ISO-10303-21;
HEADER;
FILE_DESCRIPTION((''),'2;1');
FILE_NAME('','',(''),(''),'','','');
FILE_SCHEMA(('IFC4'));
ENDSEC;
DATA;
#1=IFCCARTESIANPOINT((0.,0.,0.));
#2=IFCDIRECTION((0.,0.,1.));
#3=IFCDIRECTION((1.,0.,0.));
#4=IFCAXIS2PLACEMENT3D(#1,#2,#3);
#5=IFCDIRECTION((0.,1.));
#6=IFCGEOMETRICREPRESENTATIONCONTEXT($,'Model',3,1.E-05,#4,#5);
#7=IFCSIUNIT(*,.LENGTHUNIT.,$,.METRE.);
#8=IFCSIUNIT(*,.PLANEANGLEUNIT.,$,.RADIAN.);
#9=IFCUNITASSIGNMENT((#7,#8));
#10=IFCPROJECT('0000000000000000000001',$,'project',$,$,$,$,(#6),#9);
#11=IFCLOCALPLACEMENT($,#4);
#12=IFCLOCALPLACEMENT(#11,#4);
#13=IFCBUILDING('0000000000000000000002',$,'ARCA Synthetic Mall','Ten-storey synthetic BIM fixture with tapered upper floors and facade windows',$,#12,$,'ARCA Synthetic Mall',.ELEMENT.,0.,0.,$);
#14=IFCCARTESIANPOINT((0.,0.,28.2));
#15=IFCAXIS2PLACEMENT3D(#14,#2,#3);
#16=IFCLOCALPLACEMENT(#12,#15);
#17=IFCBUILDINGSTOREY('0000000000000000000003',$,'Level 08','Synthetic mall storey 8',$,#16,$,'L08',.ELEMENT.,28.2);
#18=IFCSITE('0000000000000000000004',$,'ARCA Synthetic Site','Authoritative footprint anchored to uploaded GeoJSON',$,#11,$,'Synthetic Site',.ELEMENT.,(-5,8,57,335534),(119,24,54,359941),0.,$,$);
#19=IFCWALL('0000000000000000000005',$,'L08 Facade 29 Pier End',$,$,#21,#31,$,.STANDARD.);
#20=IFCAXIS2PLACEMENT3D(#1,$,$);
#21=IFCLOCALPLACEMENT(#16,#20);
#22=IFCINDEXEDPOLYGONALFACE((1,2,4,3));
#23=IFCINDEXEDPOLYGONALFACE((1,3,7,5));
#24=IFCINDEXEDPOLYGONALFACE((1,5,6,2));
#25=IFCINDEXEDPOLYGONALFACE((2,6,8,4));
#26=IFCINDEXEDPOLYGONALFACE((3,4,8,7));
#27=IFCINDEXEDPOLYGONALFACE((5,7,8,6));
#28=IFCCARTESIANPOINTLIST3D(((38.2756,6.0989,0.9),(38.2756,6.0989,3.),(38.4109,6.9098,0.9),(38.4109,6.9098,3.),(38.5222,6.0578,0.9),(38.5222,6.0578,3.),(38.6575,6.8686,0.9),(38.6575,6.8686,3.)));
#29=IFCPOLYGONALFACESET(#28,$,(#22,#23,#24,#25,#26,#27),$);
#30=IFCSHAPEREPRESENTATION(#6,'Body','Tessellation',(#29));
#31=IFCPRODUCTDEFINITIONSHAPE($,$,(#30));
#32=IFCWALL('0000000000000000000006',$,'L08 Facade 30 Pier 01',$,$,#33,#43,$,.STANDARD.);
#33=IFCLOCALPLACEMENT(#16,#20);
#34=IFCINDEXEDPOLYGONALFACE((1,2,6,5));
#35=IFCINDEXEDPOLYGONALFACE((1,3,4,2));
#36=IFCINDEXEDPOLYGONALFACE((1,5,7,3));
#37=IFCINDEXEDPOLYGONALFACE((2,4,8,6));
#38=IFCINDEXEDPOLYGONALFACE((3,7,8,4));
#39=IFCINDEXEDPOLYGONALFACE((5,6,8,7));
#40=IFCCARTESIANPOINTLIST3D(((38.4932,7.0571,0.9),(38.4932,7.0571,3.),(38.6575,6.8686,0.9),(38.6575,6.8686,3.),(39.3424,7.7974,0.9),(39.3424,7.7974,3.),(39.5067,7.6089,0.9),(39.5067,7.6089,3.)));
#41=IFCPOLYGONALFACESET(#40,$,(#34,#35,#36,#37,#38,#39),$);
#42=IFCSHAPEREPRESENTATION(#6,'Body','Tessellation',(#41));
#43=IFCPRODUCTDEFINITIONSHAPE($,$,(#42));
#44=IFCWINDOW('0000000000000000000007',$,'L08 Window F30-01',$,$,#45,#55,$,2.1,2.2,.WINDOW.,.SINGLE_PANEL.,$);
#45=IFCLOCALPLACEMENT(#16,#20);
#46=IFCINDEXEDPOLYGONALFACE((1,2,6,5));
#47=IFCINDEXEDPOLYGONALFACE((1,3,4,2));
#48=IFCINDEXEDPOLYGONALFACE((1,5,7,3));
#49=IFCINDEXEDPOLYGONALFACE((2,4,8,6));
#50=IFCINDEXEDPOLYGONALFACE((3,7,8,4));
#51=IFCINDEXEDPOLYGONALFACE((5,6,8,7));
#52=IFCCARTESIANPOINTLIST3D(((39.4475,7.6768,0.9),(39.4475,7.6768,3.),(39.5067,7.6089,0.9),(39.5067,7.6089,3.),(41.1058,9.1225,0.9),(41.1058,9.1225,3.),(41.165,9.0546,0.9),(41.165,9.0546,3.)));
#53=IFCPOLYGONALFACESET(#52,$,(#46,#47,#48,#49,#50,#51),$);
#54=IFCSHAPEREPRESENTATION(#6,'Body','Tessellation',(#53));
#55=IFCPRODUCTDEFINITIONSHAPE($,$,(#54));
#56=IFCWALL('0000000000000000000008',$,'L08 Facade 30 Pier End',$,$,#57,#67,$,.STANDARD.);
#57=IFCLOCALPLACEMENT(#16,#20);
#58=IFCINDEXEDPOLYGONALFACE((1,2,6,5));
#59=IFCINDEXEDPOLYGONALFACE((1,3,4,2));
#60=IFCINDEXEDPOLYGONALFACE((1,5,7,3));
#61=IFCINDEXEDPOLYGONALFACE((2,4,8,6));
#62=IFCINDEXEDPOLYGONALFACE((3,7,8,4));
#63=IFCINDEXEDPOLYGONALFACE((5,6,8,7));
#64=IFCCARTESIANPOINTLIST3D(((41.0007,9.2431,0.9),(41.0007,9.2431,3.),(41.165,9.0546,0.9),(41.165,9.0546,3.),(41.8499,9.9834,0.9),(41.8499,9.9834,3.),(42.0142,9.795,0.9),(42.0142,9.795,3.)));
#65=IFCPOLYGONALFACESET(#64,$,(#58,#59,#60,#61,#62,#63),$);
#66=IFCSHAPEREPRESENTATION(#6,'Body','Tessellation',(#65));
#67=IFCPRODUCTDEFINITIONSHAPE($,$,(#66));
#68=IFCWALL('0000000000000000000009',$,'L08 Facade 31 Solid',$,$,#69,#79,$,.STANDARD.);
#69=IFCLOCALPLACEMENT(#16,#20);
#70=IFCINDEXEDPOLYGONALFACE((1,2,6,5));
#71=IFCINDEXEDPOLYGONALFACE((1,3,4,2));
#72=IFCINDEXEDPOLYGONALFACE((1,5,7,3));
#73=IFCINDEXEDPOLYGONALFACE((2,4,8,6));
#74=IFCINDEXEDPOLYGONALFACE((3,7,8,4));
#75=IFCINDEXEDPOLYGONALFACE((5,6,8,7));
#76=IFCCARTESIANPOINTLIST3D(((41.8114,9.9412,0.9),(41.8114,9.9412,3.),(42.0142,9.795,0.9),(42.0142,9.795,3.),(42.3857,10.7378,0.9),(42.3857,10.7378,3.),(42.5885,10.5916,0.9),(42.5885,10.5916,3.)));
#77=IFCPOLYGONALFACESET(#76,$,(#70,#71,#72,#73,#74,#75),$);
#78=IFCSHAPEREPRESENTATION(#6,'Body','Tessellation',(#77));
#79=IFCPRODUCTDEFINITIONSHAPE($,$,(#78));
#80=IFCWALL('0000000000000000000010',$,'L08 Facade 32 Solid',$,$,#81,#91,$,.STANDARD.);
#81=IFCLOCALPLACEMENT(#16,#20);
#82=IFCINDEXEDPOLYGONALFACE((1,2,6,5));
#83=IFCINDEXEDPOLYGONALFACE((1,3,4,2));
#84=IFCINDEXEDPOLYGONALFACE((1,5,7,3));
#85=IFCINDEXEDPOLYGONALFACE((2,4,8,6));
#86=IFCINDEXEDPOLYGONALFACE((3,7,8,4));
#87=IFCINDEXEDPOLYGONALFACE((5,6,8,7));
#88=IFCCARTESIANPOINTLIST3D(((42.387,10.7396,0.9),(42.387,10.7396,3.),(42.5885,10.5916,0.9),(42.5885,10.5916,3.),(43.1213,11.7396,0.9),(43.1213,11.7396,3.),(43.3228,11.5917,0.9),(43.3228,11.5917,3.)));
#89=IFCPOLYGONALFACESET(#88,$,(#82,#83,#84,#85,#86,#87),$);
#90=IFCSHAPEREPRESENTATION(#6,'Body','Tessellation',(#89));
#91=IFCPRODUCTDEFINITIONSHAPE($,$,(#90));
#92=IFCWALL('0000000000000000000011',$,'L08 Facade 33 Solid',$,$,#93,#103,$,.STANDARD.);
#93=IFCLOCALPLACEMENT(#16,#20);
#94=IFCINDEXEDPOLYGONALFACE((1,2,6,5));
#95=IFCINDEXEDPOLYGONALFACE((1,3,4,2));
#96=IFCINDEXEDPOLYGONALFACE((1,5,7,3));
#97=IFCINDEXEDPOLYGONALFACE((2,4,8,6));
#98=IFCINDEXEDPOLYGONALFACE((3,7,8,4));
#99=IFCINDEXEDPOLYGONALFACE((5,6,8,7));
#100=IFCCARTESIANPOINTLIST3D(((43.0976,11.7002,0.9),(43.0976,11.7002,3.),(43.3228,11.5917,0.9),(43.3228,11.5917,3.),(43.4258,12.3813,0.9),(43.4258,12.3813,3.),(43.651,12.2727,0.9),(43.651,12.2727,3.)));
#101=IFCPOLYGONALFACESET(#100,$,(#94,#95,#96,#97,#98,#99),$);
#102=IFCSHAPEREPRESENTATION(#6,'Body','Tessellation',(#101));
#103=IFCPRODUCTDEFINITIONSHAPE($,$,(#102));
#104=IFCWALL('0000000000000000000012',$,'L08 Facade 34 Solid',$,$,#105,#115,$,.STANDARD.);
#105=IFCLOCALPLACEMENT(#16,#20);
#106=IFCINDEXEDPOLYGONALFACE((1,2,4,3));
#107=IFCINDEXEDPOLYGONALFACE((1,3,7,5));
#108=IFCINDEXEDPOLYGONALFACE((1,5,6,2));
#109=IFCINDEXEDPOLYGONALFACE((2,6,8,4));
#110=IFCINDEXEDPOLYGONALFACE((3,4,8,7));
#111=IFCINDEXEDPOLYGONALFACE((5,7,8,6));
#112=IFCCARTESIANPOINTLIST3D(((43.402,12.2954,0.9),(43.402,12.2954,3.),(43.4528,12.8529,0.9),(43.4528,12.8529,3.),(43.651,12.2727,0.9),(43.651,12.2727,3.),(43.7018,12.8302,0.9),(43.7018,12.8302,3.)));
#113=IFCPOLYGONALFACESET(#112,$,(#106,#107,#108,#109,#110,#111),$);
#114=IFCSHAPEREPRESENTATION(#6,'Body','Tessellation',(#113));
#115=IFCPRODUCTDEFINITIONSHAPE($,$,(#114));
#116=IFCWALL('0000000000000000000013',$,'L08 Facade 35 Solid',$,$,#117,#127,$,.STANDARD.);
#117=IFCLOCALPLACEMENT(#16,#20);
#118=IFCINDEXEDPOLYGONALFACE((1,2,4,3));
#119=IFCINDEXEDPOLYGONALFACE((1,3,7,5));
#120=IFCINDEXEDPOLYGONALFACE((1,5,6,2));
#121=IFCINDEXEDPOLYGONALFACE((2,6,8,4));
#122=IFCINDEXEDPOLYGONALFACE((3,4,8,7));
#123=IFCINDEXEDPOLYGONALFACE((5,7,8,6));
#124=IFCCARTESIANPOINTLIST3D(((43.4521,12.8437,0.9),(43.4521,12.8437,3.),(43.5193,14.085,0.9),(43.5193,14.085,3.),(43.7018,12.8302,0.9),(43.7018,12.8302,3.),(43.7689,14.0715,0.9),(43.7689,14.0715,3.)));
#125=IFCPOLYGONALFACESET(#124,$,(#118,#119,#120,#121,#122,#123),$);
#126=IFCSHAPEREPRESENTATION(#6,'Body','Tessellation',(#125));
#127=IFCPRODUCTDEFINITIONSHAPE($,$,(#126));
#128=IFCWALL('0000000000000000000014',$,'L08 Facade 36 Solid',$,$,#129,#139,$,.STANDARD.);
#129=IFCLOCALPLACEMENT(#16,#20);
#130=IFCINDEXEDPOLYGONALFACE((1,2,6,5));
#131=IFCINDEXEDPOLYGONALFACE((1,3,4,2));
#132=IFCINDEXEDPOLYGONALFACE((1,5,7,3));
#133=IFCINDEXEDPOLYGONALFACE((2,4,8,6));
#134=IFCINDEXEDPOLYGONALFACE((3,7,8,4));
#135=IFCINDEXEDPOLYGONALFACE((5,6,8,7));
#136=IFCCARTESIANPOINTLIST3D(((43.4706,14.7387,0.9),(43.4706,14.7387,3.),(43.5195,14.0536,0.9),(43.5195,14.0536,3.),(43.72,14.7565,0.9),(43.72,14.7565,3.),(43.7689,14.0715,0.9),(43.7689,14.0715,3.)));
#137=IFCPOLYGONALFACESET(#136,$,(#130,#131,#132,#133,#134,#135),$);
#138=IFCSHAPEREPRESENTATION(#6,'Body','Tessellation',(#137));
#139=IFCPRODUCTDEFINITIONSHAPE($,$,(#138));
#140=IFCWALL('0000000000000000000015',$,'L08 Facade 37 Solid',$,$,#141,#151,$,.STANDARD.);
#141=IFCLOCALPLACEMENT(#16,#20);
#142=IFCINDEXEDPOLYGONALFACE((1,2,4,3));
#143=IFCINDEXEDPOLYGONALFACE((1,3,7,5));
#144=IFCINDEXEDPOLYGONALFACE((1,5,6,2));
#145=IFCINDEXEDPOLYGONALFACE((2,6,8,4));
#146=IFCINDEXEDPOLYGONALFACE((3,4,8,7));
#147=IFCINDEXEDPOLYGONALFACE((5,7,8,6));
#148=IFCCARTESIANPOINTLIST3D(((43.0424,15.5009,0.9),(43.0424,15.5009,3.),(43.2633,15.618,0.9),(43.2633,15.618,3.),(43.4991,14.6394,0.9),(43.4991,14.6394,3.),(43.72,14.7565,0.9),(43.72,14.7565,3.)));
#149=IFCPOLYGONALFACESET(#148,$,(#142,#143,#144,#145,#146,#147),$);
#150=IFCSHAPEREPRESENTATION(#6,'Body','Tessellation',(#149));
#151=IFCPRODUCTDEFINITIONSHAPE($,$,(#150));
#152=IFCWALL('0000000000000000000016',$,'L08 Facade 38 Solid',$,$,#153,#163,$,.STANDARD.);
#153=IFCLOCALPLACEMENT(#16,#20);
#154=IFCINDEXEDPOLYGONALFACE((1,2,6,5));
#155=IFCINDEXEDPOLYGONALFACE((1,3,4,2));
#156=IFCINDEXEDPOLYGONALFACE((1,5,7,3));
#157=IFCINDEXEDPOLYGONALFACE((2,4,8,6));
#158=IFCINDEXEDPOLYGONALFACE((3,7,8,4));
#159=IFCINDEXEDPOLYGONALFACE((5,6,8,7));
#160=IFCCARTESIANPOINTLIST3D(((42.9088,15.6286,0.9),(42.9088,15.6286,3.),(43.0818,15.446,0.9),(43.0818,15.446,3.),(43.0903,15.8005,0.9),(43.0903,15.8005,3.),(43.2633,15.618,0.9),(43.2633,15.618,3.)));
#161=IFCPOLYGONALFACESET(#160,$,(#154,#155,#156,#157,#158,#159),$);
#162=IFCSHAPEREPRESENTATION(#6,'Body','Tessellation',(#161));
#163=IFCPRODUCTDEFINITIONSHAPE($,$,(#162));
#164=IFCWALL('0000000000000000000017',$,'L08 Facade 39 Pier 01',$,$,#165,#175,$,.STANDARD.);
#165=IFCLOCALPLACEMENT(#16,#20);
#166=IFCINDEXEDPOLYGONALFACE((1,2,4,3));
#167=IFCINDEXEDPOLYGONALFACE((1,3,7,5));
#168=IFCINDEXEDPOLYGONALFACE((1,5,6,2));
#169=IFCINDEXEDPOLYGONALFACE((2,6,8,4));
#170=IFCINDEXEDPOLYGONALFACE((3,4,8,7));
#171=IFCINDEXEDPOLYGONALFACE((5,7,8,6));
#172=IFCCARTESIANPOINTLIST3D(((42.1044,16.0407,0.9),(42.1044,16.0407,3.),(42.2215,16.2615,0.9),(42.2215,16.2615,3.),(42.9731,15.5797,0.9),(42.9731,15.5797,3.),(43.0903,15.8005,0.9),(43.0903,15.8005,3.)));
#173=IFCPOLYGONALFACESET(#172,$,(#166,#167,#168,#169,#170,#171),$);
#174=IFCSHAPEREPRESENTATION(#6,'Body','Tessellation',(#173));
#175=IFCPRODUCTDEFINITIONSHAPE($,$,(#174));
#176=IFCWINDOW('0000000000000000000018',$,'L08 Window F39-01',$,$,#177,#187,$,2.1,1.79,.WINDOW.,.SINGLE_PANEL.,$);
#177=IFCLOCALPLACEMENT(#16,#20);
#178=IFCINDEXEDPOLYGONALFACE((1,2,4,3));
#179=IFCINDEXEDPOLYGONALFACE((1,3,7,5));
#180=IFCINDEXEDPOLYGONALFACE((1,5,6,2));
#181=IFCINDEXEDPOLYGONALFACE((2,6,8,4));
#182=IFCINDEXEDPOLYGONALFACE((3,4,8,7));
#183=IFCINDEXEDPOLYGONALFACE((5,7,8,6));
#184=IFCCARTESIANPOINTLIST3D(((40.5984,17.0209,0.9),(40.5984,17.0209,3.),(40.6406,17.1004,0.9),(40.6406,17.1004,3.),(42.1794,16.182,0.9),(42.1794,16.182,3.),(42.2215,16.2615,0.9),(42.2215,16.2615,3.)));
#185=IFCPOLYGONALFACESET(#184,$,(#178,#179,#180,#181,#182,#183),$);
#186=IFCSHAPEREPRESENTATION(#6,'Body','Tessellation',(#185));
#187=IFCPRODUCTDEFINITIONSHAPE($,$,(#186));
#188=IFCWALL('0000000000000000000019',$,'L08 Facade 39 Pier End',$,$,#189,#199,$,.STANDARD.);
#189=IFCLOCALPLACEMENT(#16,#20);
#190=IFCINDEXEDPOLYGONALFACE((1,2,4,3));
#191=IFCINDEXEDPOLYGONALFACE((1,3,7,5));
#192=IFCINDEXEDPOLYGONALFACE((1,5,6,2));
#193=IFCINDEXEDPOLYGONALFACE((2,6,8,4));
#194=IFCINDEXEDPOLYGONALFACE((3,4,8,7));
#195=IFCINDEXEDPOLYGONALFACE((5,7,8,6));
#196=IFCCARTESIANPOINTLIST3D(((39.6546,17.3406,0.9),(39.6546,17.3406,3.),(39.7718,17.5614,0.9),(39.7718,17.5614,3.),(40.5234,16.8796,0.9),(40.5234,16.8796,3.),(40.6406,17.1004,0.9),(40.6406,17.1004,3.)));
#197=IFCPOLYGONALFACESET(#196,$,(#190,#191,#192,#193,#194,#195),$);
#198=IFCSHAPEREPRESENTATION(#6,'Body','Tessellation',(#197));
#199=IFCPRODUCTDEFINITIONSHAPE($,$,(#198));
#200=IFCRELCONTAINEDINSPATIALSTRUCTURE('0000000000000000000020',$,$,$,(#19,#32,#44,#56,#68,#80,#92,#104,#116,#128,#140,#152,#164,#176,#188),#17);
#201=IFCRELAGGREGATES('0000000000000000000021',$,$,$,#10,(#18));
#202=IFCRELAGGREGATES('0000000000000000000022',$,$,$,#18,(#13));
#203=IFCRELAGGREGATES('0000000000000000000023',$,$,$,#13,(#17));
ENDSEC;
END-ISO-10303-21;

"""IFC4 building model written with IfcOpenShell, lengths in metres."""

from ifc_helpers import new_model, si_unit, direction, frame, origin_with_axes, place, context, project, spatial, polyline, outline, extrude, element, save


model = new_model("IFC4")

# Units and contexts
model_context = context("Model", 3, precision=1e-05, world=origin_with_axes(), true_north=direction((0.0, 1.0)))
ifc_project = project(units=[si_unit("LENGTHUNIT", "METRE"), si_unit("PLANEANGLEUNIT", "RADIAN")], contexts=[model_context])

# Site, building, storey
site_placement = place(None, origin_with_axes())
site = spatial("IfcSite", under=ifc_project, at=site_placement, Name="ARCA Synthetic Site", Description="Authoritative footprint anchored to uploaded GeoJSON", LongName="Synthetic Site", CompositionType="ELEMENT", RefLatitude=(-5, 8, 57, 335534), RefLongitude=(119, 24, 54, 359941), RefElevation=0.0)
building_placement = place(site_placement, origin_with_axes())
building = spatial("IfcBuilding", under=site, at=building_placement, Name="ARCA Synthetic Mall", Description="Ten-storey synthetic BIM fixture with tapered upper floors and facade windows", LongName="ARCA Synthetic Mall", CompositionType="ELEMENT", ElevationOfRefHeight=0.0, ElevationOfTerrain=0.0)
storey_placement = place(building_placement, frame((0.0, 0.0, 28.2), z_axis=(0.0, 0.0, 1.0), x_axis=(1.0, 0.0, 0.0)))
storey = spatial("IfcBuildingStorey", under=building, at=storey_placement, Name="Level 08", Description="Synthetic mall storey 8", LongName="L08", CompositionType="ELEMENT", Elevation=28.2)

# Walls
wall_1_placement = place(storey_placement, frame((0.0, 0.0, 0.9), z_axis=(0.0, 0.0, 1.0), x_axis=(1.0, 0.0, 0.0)))
element("IfcWall", 1, at=wall_1_placement, inside=storey, Name="L08 Facade 29 Pier End", PredefinedType="STANDARD", context=model_context, shape_type="SweptSolid", body=[
    extrude(outline(polyline([(38.5222, 6.0578), (38.6575, 6.8686), (38.4109, 6.9098), (38.2756, 6.0989), (38.5222, 6.0578)])), origin_with_axes(), (0.0, 0.0, 1.0), 2.1),
])
wall_2_placement = place(storey_placement, frame((0.0, 0.0, 0.9), z_axis=(0.0, 0.0, 1.0), x_axis=(1.0, 0.0, 0.0)))
element("IfcWall", 2, at=wall_2_placement, inside=storey, Name="L08 Facade 30 Pier 01", PredefinedType="STANDARD", context=model_context, shape_type="SweptSolid", body=[
    extrude(outline(polyline([(38.6575, 6.8686), (39.5067, 7.6089), (39.3424, 7.7974), (38.4932, 7.0571), (38.6575, 6.8686)])), origin_with_axes(), (0.0, 0.0, 1.0), 2.1),
])

# Window
window_1_placement = place(storey_placement, frame((0.0, 0.0, 0.9), z_axis=(0.0, 0.0, 1.0), x_axis=(1.0, 0.0, 0.0)))
element("IfcWindow", 3, at=window_1_placement, inside=storey, Name="L08 Window F30-01", OverallHeight=2.1, OverallWidth=2.2, PartitioningType="SINGLE_PANEL", PredefinedType="WINDOW", context=model_context, shape_type="SweptSolid", body=[
    extrude(outline(polyline([(39.5067, 7.6089), (41.165, 9.0546), (41.1058, 9.1225), (39.4475, 7.6768), (39.5067, 7.6089)])), origin_with_axes(), (0.0, 0.0, 1.0), 2.1),
])

# Walls
wall_3_placement = place(storey_placement, frame((0.0, 0.0, 0.9), z_axis=(0.0, 0.0, 1.0), x_axis=(1.0, 0.0, 0.0)))
element("IfcWall", 4, at=wall_3_placement, inside=storey, Name="L08 Facade 30 Pier End", PredefinedType="STANDARD", context=model_context, shape_type="SweptSolid", body=[
    extrude(outline(polyline([(41.165, 9.0546), (42.0142, 9.795), (41.8499, 9.9834), (41.0007, 9.2431), (41.165, 9.0546)])), origin_with_axes(), (0.0, 0.0, 1.0), 2.1),
])
wall_4_placement = place(storey_placement, frame((0.0, 0.0, 0.9), z_axis=(0.0, 0.0, 1.0), x_axis=(1.0, 0.0, 0.0)))
element("IfcWall", 5, at=wall_4_placement, inside=storey, Name="L08 Facade 31 Solid", PredefinedType="STANDARD", context=model_context, shape_type="SweptSolid", body=[
    extrude(outline(polyline([(42.0142, 9.795), (42.5885, 10.5916), (42.3857, 10.7378), (41.8114, 9.9412), (42.0142, 9.795)])), origin_with_axes(), (0.0, 0.0, 1.0), 2.1),
])
wall_5_placement = place(storey_placement, frame((0.0, 0.0, 0.9), z_axis=(0.0, 0.0, 1.0), x_axis=(1.0, 0.0, 0.0)))
element("IfcWall", 6, at=wall_5_placement, inside=storey, Name="L08 Facade 32 Solid", PredefinedType="STANDARD", context=model_context, shape_type="SweptSolid", body=[
    extrude(outline(polyline([(42.5885, 10.5916), (43.3228, 11.5917), (43.1213, 11.7396), (42.387, 10.7396), (42.5885, 10.5916)])), origin_with_axes(), (0.0, 0.0, 1.0), 2.1),
])
wall_6_placement = place(storey_placement, frame((0.0, 0.0, 0.9), z_axis=(0.0, 0.0, 1.0), x_axis=(1.0, 0.0, 0.0)))
element("IfcWall", 7, at=wall_6_placement, inside=storey, Name="L08 Facade 33 Solid", PredefinedType="STANDARD", context=model_context, shape_type="SweptSolid", body=[
    extrude(outline(polyline([(43.3228, 11.5917), (43.651, 12.2727), (43.4258, 12.3813), (43.0976, 11.7002), (43.3228, 11.5917)])), origin_with_axes(), (0.0, 0.0, 1.0), 2.1),
])
wall_7_placement = place(storey_placement, frame((0.0, 0.0, 0.9), z_axis=(0.0, 0.0, 1.0), x_axis=(1.0, 0.0, 0.0)))
element("IfcWall", 8, at=wall_7_placement, inside=storey, Name="L08 Facade 34 Solid", PredefinedType="STANDARD", context=model_context, shape_type="SweptSolid", body=[
    extrude(outline(polyline([(43.651, 12.2727), (43.7018, 12.8302), (43.4528, 12.8529), (43.402, 12.2954), (43.651, 12.2727)])), origin_with_axes(), (0.0, 0.0, 1.0), 2.1),
])
wall_8_placement = place(storey_placement, frame((0.0, 0.0, 0.9), z_axis=(0.0, 0.0, 1.0), x_axis=(1.0, 0.0, 0.0)))
element("IfcWall", 9, at=wall_8_placement, inside=storey, Name="L08 Facade 35 Solid", PredefinedType="STANDARD", context=model_context, shape_type="SweptSolid", body=[
    extrude(outline(polyline([(43.7018, 12.8302), (43.7689, 14.0715), (43.5193, 14.085), (43.4521, 12.8437), (43.7018, 12.8302)])), origin_with_axes(), (0.0, 0.0, 1.0), 2.1),
])
wall_9_placement = place(storey_placement, frame((0.0, 0.0, 0.9), z_axis=(0.0, 0.0, 1.0), x_axis=(1.0, 0.0, 0.0)))
element("IfcWall", 10, at=wall_9_placement, inside=storey, Name="L08 Facade 36 Solid", PredefinedType="STANDARD", context=model_context, shape_type="SweptSolid", body=[
    extrude(outline(polyline([(43.7689, 14.0715), (43.72, 14.7565), (43.4706, 14.7387), (43.5195, 14.0536), (43.7689, 14.0715)])), origin_with_axes(), (0.0, 0.0, 1.0), 2.1),
])
wall_10_placement = place(storey_placement, frame((0.0, 0.0, 0.9), z_axis=(0.0, 0.0, 1.0), x_axis=(1.0, 0.0, 0.0)))
element("IfcWall", 11, at=wall_10_placement, inside=storey, Name="L08 Facade 37 Solid", PredefinedType="STANDARD", context=model_context, shape_type="SweptSolid", body=[
    extrude(outline(polyline([(43.72, 14.7565), (43.2633, 15.618), (43.0424, 15.5009), (43.4991, 14.6394), (43.72, 14.7565)])), origin_with_axes(), (0.0, 0.0, 1.0), 2.1),
])
wall_11_placement = place(storey_placement, frame((0.0, 0.0, 0.9), z_axis=(0.0, 0.0, 1.0), x_axis=(1.0, 0.0, 0.0)))
element("IfcWall", 12, at=wall_11_placement, inside=storey, Name="L08 Facade 38 Solid", PredefinedType="STANDARD", context=model_context, shape_type="SweptSolid", body=[
    extrude(outline(polyline([(43.2633, 15.618), (43.0903, 15.8005), (42.9088, 15.6286), (43.0818, 15.446), (43.2633, 15.618)])), origin_with_axes(), (0.0, 0.0, 1.0), 2.1),
])
wall_12_placement = place(storey_placement, frame((0.0, 0.0, 0.9), z_axis=(0.0, 0.0, 1.0), x_axis=(1.0, 0.0, 0.0)))
element("IfcWall", 13, at=wall_12_placement, inside=storey, Name="L08 Facade 39 Pier 01", PredefinedType="STANDARD", context=model_context, shape_type="SweptSolid", body=[
    extrude(outline(polyline([(43.0903, 15.8005), (42.2215, 16.2615), (42.1044, 16.0407), (42.9731, 15.5797), (43.0903, 15.8005)])), origin_with_axes(), (0.0, 0.0, 1.0), 2.1),
])

# Window
window_2_placement = place(storey_placement, frame((0.0, 0.0, 0.9), z_axis=(0.0, 0.0, 1.0), x_axis=(1.0, 0.0, 0.0)))
element("IfcWindow", 14, at=window_2_placement, inside=storey, Name="L08 Window F39-01", OverallHeight=2.1, OverallWidth=1.79, PartitioningType="SINGLE_PANEL", PredefinedType="WINDOW", context=model_context, shape_type="SweptSolid", body=[
    extrude(outline(polyline([(42.2215, 16.2615), (40.6406, 17.1004), (40.5984, 17.0209), (42.1794, 16.182), (42.2215, 16.2615)])), origin_with_axes(), (0.0, 0.0, 1.0), 2.1),
])

# Wall
wall_13_placement = place(storey_placement, frame((0.0, 0.0, 0.9), z_axis=(0.0, 0.0, 1.0), x_axis=(1.0, 0.0, 0.0)))
element("IfcWall", 15, at=wall_13_placement, inside=storey, Name="L08 Facade 39 Pier End", PredefinedType="STANDARD", context=model_context, shape_type="SweptSolid", body=[
    extrude(outline(polyline([(40.6406, 17.1004), (39.7718, 17.5614), (39.6546, 17.3406), (40.5234, 16.8796), (40.6406, 17.1004)])), origin_with_axes(), (0.0, 0.0, 1.0), 2.1),
])

save(model, "model.ifc")
